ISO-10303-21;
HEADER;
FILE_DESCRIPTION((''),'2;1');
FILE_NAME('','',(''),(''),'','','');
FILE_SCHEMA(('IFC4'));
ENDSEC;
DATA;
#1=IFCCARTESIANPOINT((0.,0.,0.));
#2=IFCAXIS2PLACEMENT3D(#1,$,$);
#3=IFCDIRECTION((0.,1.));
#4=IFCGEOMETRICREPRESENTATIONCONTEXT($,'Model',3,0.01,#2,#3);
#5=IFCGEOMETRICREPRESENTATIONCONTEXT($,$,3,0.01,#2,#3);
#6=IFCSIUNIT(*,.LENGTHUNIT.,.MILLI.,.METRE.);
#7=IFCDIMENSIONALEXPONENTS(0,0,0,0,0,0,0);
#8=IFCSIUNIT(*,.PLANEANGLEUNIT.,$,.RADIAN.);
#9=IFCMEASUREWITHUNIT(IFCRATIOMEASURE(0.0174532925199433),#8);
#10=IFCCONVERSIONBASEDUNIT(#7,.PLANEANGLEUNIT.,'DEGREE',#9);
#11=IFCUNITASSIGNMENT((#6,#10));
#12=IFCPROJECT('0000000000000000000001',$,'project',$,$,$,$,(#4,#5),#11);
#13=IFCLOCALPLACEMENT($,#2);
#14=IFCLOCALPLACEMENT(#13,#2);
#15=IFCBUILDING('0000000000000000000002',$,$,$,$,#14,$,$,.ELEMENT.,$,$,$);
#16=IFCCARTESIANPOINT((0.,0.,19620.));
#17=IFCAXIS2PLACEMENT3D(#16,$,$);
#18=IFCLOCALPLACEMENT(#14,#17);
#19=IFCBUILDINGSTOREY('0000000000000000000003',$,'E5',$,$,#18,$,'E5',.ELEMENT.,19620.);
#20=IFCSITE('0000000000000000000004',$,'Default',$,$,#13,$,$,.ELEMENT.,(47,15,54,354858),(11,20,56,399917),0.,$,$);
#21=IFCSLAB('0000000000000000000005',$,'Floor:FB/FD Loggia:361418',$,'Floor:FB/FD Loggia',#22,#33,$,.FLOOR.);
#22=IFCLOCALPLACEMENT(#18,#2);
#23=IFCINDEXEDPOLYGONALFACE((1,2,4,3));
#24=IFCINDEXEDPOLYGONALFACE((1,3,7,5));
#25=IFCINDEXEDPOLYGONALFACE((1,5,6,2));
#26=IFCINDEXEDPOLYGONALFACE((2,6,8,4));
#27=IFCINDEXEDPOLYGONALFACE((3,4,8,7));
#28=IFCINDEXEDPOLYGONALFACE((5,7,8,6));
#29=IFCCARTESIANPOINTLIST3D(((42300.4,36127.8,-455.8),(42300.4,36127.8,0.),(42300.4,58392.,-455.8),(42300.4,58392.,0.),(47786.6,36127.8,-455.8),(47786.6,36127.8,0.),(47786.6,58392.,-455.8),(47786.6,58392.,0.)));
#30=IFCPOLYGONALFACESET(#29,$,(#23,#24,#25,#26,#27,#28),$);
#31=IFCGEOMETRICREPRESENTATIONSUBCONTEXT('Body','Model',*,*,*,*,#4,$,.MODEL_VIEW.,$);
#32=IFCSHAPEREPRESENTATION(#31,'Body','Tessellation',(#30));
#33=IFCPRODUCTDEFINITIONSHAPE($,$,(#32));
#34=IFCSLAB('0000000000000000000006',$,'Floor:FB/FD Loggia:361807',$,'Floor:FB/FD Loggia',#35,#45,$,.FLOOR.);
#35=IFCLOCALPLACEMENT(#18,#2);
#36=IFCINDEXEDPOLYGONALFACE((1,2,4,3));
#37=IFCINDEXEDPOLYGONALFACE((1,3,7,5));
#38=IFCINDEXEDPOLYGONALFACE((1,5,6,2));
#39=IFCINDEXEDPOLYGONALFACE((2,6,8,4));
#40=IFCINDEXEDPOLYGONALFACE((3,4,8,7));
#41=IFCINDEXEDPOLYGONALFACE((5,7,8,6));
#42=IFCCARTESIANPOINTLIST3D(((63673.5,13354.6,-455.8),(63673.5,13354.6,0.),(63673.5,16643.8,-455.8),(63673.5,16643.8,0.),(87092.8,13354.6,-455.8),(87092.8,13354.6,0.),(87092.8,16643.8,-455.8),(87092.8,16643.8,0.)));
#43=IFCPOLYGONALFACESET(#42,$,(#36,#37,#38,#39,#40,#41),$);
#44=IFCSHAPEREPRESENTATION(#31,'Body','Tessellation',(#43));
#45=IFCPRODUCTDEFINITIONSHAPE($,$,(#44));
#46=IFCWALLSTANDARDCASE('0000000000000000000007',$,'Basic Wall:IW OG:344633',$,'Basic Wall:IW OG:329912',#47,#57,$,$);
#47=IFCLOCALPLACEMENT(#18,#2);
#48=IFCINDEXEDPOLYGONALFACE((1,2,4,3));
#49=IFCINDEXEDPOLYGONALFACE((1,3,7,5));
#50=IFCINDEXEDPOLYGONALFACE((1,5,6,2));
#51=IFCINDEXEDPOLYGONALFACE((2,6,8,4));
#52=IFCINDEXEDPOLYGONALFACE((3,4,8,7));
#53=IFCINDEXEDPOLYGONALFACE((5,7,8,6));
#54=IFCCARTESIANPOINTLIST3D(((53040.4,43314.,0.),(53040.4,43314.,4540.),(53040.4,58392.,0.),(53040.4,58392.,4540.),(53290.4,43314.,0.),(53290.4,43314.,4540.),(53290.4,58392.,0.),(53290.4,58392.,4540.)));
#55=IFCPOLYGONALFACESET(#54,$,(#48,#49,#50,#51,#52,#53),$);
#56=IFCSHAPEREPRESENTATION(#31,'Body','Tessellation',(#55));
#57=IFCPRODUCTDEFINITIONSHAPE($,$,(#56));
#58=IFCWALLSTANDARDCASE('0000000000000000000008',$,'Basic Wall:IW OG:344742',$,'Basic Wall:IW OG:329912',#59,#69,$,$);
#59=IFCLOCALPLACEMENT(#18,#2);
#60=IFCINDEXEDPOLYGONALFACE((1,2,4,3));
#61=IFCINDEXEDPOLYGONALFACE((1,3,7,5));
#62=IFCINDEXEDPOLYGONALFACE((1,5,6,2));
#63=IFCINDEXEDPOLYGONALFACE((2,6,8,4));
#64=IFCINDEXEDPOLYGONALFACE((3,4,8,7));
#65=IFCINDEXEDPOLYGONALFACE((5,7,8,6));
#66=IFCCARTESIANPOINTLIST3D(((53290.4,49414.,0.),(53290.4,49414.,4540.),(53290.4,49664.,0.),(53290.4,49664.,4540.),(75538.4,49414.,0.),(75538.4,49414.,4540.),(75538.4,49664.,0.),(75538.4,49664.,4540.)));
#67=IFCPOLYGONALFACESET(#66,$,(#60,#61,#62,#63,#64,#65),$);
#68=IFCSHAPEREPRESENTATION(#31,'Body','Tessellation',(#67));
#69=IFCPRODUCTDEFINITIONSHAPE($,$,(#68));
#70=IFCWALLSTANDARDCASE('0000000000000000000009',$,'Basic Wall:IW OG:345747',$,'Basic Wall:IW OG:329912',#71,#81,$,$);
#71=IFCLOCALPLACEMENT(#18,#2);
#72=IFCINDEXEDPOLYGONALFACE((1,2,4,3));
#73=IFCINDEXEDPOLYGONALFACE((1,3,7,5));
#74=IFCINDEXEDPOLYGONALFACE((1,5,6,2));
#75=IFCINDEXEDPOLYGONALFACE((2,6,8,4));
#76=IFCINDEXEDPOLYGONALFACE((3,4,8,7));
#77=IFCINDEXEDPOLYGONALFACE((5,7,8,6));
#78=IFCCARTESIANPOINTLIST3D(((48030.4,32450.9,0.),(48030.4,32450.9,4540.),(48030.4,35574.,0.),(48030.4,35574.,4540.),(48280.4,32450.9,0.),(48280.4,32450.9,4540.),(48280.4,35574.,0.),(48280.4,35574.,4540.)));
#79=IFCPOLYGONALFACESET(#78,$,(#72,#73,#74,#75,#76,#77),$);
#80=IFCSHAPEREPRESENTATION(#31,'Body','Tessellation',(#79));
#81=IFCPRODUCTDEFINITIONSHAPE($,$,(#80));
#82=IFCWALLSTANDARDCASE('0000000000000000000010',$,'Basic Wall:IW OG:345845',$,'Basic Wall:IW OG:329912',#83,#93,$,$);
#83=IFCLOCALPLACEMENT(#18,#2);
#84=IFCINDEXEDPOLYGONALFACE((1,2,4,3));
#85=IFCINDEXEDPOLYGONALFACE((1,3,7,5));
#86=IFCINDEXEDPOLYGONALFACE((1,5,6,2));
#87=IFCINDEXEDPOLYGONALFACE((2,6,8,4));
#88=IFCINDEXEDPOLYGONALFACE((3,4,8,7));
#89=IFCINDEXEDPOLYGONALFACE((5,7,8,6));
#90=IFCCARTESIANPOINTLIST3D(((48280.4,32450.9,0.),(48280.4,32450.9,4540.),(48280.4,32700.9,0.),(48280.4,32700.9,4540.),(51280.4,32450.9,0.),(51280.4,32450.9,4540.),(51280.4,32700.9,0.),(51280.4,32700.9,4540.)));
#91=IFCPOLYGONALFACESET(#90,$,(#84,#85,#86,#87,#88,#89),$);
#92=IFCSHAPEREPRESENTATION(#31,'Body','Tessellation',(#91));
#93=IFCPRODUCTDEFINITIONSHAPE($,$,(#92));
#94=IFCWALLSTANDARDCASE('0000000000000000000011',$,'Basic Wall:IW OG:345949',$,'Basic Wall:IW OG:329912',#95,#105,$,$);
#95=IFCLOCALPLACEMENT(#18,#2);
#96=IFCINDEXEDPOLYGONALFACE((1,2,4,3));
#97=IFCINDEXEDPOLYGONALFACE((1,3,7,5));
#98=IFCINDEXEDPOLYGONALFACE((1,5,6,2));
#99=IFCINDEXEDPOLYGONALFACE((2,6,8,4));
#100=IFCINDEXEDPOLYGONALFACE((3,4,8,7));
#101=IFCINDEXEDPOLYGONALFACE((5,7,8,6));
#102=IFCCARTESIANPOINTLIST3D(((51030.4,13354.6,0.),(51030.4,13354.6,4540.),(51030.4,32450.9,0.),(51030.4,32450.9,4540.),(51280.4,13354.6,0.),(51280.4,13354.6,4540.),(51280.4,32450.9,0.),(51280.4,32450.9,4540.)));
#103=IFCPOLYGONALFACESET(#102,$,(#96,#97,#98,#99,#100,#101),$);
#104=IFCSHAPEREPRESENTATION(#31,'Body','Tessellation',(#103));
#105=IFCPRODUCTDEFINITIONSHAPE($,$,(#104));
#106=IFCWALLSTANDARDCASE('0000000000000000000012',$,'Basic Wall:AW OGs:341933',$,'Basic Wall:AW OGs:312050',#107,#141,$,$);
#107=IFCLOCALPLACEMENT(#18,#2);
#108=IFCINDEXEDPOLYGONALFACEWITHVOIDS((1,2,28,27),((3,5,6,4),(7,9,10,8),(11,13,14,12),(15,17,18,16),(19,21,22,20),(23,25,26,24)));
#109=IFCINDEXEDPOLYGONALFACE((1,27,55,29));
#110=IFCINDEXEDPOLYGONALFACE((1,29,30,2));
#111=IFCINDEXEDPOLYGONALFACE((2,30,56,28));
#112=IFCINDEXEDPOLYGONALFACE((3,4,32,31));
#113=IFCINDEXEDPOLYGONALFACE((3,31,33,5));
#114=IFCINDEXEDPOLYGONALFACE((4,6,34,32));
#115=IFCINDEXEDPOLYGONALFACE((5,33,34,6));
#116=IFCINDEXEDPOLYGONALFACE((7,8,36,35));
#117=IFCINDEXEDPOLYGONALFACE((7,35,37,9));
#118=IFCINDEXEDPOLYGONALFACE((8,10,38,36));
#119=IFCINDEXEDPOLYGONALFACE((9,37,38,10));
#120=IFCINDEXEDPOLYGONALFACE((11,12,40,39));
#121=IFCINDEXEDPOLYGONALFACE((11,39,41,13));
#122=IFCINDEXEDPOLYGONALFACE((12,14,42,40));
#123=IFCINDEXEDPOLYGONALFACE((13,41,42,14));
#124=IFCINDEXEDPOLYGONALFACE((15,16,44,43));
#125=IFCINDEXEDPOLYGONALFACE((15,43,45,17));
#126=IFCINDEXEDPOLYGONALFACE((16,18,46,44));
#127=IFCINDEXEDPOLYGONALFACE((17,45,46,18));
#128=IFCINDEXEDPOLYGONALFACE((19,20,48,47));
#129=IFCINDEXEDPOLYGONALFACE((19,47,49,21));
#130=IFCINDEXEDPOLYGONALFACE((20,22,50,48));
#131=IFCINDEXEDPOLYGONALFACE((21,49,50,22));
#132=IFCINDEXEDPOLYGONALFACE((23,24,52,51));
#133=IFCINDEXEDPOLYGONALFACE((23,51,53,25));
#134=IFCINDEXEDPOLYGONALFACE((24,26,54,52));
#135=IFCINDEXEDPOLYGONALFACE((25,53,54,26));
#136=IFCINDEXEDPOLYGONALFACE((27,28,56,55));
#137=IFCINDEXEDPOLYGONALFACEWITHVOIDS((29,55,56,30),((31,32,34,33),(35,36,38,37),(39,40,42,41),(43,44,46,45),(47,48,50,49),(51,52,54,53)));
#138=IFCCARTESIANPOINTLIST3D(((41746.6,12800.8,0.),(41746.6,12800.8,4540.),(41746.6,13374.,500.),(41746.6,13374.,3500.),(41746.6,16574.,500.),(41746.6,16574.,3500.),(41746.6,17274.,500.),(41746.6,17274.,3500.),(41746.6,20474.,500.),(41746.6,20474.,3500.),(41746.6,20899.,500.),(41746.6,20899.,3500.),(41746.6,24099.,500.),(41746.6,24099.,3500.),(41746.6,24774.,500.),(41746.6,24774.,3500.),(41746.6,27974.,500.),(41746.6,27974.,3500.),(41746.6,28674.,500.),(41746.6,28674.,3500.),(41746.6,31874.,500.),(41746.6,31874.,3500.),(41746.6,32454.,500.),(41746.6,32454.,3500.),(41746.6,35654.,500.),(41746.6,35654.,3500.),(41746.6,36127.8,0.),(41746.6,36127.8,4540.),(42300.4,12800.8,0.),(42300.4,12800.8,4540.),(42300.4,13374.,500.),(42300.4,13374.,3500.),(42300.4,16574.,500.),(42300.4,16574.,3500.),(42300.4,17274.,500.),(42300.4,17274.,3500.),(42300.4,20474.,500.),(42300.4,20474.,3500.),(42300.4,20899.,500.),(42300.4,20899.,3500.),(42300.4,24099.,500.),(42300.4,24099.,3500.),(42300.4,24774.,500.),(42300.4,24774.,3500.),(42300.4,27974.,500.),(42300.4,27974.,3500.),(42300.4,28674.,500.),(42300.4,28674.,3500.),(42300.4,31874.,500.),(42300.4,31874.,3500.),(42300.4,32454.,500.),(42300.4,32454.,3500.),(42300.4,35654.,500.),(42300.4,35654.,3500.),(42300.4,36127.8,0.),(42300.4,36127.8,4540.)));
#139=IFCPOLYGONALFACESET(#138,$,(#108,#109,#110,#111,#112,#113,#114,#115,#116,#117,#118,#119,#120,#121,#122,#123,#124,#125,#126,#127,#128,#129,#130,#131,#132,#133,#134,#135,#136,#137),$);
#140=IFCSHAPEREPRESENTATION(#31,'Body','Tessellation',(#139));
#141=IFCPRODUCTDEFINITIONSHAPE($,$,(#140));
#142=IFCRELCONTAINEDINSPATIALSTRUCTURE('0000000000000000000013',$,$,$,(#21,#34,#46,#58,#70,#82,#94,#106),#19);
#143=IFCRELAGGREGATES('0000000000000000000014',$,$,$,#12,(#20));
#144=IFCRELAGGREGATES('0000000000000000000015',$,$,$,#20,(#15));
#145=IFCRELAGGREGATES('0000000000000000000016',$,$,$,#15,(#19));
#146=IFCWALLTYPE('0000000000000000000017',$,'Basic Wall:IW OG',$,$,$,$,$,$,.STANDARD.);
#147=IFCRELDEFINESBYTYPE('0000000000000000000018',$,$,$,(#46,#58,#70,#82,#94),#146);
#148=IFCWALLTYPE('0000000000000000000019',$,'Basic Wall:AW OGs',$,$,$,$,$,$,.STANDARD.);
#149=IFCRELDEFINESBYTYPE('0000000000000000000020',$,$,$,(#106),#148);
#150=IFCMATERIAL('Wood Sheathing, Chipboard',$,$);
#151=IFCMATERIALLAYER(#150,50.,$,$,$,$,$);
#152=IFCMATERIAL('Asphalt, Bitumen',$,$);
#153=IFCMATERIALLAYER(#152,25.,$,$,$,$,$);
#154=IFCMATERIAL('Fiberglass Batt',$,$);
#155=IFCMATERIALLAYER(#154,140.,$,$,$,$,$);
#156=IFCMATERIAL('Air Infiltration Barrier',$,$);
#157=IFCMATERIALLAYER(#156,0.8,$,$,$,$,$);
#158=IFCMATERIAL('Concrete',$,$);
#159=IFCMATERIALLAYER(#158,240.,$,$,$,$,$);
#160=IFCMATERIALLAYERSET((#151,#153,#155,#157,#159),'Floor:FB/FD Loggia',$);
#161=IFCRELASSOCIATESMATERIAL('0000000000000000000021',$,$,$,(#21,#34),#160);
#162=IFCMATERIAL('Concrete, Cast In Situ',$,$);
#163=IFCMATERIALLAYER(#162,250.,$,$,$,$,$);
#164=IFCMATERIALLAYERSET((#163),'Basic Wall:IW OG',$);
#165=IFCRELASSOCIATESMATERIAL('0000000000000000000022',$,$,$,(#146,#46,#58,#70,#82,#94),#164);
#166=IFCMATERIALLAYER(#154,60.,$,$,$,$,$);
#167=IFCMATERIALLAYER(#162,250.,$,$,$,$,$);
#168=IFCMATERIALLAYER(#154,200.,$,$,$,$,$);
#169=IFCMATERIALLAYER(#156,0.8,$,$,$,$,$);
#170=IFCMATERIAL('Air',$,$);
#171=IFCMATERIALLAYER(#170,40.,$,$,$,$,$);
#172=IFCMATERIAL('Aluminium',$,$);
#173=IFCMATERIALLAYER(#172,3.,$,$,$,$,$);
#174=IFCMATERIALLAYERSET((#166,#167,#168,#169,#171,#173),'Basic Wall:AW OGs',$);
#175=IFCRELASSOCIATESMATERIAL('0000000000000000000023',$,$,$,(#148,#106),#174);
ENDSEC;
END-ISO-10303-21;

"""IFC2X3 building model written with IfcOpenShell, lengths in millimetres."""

from ifc_helpers import new_model, entity, si_unit, converted_unit, direction, frame, frame_2d, origin, place, context, subcontext, project, spatial, rectangle, extrude, material, layer, layer_set, layer_usage, type_object, element, save


model = new_model("IFC2X3")

# Units and contexts
model_context = context("Model", 3, precision=0.01, world=origin(), true_north=direction((0.0, 1.0)))
context_of_model = context(None, 3, precision=0.01, world=origin(), true_north=direction((0.0, 1.0)))
body_context = subcontext(model_context, "Body", "Model", "MODEL_VIEW")
ifc_project = project(units=[si_unit("LENGTHUNIT", "METRE", prefix="MILLI"), converted_unit("PLANEANGLEUNIT", "DEGREE", entity("IfcRatioMeasure", 0.0174532925199433), si_unit("PLANEANGLEUNIT", "RADIAN"), dimensions=[0, 0, 0, 0, 0, 0, 0])], contexts=[model_context, context_of_model])

# Site, building, storey
site_placement = place(None, origin())
site = spatial("IfcSite", under=ifc_project, at=site_placement, Name="Default", CompositionType="ELEMENT", RefLatitude=(47, 15, 54, 354858), RefLongitude=(11, 20, 56, 399917), RefElevation=0.0)
building_placement = place(site_placement, origin())
building = spatial("IfcBuilding", under=site, at=building_placement, CompositionType="ELEMENT")
storey_placement = place(building_placement, frame((0.0, 0.0, 19620.0)))
storey = spatial("IfcBuildingStorey", under=building, at=storey_placement, Name="E5", LongName="E5", CompositionType="ELEMENT", Elevation=19620.0)

# Shared definitions
ifc_material_1 = material(Name="Air Infiltration Barrier")
ifc_material_2 = material(Name="Fiberglass Batt")
ifc_material_3 = material(Name="Concrete")

# Slabs
ifc_material_4 = material(Name="Wood Sheathing, Chipboard")
ifc_layer_1 = layer(ifc_material_4, 50.0)
ifc_material_5 = material(Name="Asphalt, Bitumen")
ifc_layer_2 = layer(ifc_material_5, 25.0)
ifc_layer_3 = layer(ifc_material_2, 140.0)
ifc_layer_4 = layer(ifc_material_1, 0.8)
ifc_layer_5 = layer(ifc_material_3, 240.0)
ifc_layer_set_1 = layer_set([ifc_layer_1, ifc_layer_2, ifc_layer_3, ifc_layer_4, ifc_layer_5], Name="Floor:FB/FD Loggia")
ifc_layer_usage_1 = layer_usage(ifc_layer_set_1, "AXIS3", "POSITIVE", 0.0)
slab_1_placement = place(storey_placement, origin())
element("IfcSlab", 1, at=slab_1_placement, inside=storey, material=ifc_layer_usage_1, Name="Floor:FB/FD Loggia:361418", ObjectType="Floor:FB/FD Loggia", PredefinedType="FLOOR", context=body_context, shape_type="SweptSolid", body=[
    extrude(rectangle(XDim=22264.3, YDim=5486.2, at=frame_2d((0.0, 0.0), x_axis=(1.0, 0.0))), frame((45043.5, 47259.9, 0.0), z_axis=(0.0, 0.0, -1.0), x_axis=(0.0, 1.0, 0.0)), (0.0, 0.0, 1.0), 455.8),
])
ifc_layer_usage_2 = layer_usage(ifc_layer_set_1, "AXIS3", "POSITIVE", 0.0)
slab_2_placement = place(storey_placement, origin())
element("IfcSlab", 2, at=slab_2_placement, inside=storey, material=ifc_layer_usage_2, Name="Floor:FB/FD Loggia:361807", ObjectType="Floor:FB/FD Loggia", PredefinedType="FLOOR", context=body_context, shape_type="SweptSolid", body=[
    extrude(rectangle(XDim=3289.2, YDim=23419.3, at=frame_2d((0.0, 0.0), x_axis=(1.0, 0.0))), frame((75383.1, 14999.2, 0.0), z_axis=(0.0, 0.0, -1.0), x_axis=(0.0, 1.0, 0.0)), (0.0, 0.0, 1.0), 455.8),
])

# Walls
ifc_material_6 = material(Name="Concrete, Cast In Situ")
ifc_layer_6 = layer(ifc_material_6, 250.0)
ifc_layer_set_2 = layer_set([ifc_layer_6], Name="Basic Wall:IW OG")
ifc_layer_usage_3 = layer_usage(ifc_layer_set_2, "AXIS2", "NEGATIVE", 125.0)
wall_type_1 = type_object("IfcWallType", Name="Basic Wall:IW OG", PredefinedType="STANDARD", material=ifc_layer_set_2)
wall_1_placement = place(storey_placement, frame((53165.4, 58392.0, 0.0), z_axis=(0.0, 0.0, 1.0), x_axis=(0.0, -1.0, 0.0)))
element("IfcWallStandardCase", 3, at=wall_1_placement, inside=storey, type_object=wall_type_1, material=ifc_layer_usage_3, Name="Basic Wall:IW OG:344633", ObjectType="Basic Wall:IW OG:329912", context=body_context, shape_type="SweptSolid", body=[
    extrude(rectangle(XDim=15078.0, YDim=250.0, at=frame_2d((7539.0, 0.0), x_axis=(-1.0, 0.0))), origin(), (0.0, 0.0, 1.0), 4540.0),
])
ifc_layer_usage_4 = layer_usage(ifc_layer_set_2, "AXIS2", "NEGATIVE", 125.0)
wall_2_placement = place(storey_placement, frame((53290.4, 49539.0, 0.0)))
element("IfcWallStandardCase", 4, at=wall_2_placement, inside=storey, type_object=wall_type_1, material=ifc_layer_usage_4, Name="Basic Wall:IW OG:344742", ObjectType="Basic Wall:IW OG:329912", context=body_context, shape_type="SweptSolid", body=[
    extrude(rectangle(XDim=22248.1, YDim=250.0, at=frame_2d((11124.0, 0.0), x_axis=(-1.0, 0.0))), origin(), (0.0, 0.0, 1.0), 4540.0),
])
ifc_layer_usage_5 = layer_usage(ifc_layer_set_2, "AXIS2", "NEGATIVE", 125.0)
wall_3_placement = place(storey_placement, frame((48155.4, 35574.0, 0.0), z_axis=(0.0, 0.0, 1.0), x_axis=(0.0, -1.0, 0.0)))
element("IfcWallStandardCase", 5, at=wall_3_placement, inside=storey, type_object=wall_type_1, material=ifc_layer_usage_5, Name="Basic Wall:IW OG:345747", ObjectType="Basic Wall:IW OG:329912", context=body_context, shape_type="SweptSolid", body=[
    extrude(rectangle(XDim=3123.1, YDim=250.0, at=frame_2d((1561.5, 0.0), x_axis=(-1.0, 0.0))), origin(), (0.0, 0.0, 1.0), 4540.0),
])
ifc_layer_usage_6 = layer_usage(ifc_layer_set_2, "AXIS2", "NEGATIVE", 125.0)
wall_4_placement = place(storey_placement, frame((48280.4, 32575.9, 0.0)))
element("IfcWallStandardCase", 6, at=wall_4_placement, inside=storey, type_object=wall_type_1, material=ifc_layer_usage_6, Name="Basic Wall:IW OG:345845", ObjectType="Basic Wall:IW OG:329912", context=body_context, shape_type="SweptSolid", body=[
    extrude(rectangle(XDim=3000.0, YDim=250.0, at=frame_2d((1500.0, 0.0), x_axis=(-1.0, 0.0))), origin(), (0.0, 0.0, 1.0), 4540.0),
])
ifc_layer_usage_7 = layer_usage(ifc_layer_set_2, "AXIS2", "NEGATIVE", 125.0)
wall_5_placement = place(storey_placement, frame((51155.4, 32450.9, 0.0), z_axis=(0.0, 0.0, 1.0), x_axis=(0.0, -1.0, 0.0)))
element("IfcWallStandardCase", 7, at=wall_5_placement, inside=storey, type_object=wall_type_1, material=ifc_layer_usage_7, Name="Basic Wall:IW OG:345949", ObjectType="Basic Wall:IW OG:329912", context=body_context, shape_type="SweptSolid", body=[
    extrude(rectangle(XDim=19096.2, YDim=250.0, at=frame_2d((9548.1, 0.0), x_axis=(-1.0, 0.0))), origin(), (0.0, 0.0, 1.0), 4540.0),
])

# Wall, openings
ifc_layer_7 = layer(ifc_material_2, 60.0)
ifc_layer_8 = layer(ifc_material_6, 250.0)
ifc_layer_9 = layer(ifc_material_2, 200.0)
ifc_layer_10 = layer(ifc_material_1, 0.8)
ifc_material_7 = material(Name="Air")
ifc_layer_11 = layer(ifc_material_7, 40.0)
ifc_material_8 = material(Name="Aluminium")
ifc_layer_12 = layer(ifc_material_8, 3.0)
ifc_layer_set_3 = layer_set([ifc_layer_7, ifc_layer_8, ifc_layer_9, ifc_layer_10, ifc_layer_11, ifc_layer_12], Name="Basic Wall:AW OGs")
ifc_layer_usage_8 = layer_usage(ifc_layer_set_3, "AXIS2", "NEGATIVE", 276.9)
wall_type_2 = type_object("IfcWallType", Name="Basic Wall:AW OGs", PredefinedType="STANDARD", material=ifc_layer_set_3)
wall_6_placement = place(storey_placement, frame((42023.5, 36127.8, 0.0), z_axis=(0.0, 0.0, 1.0), x_axis=(0.0, -1.0, 0.0)))
wall_6 = element("IfcWallStandardCase", 8, at=wall_6_placement, inside=storey, type_object=wall_type_2, material=ifc_layer_usage_8, Name="Basic Wall:AW OGs:341933", ObjectType="Basic Wall:AW OGs:312050", context=body_context, shape_type="SweptSolid", body=[
    extrude(rectangle(XDim=23326.9, YDim=553.8, at=frame_2d((11663.5, 0.0), x_axis=(-1.0, 0.0))), origin(), (0.0, 0.0, 1.0), 4540.0),
])
opening_1_placement = place(wall_6_placement, origin())
element("IfcOpeningElement", 9, at=opening_1_placement, cuts=wall_6, ObjectType="Opening", context=body_context, shape_type="SweptSolid", body=[
    extrude(rectangle(XDim=3000.0, YDim=553.8, at=frame_2d((0.0, 0.0), x_axis=(0.0, 1.0))), frame((23050.0, 276.9, 2000.0), z_axis=(0.0, 1.0, 0.0), x_axis=(-1.0, 0.0, 0.0)), (0.0, 0.0, 1.0), 8500.0),
])
opening_2_placement = place(wall_6_placement, frame((3673.8, 276.9, 500.0)))
element("IfcOpeningElement", 10, at=opening_2_placement, cuts=wall_6, ObjectType="Opening", context=body_context, shape_type="SweptSolid", body=[
    extrude(rectangle(XDim=3000.0, YDim=3200.0, at=frame_2d((1500.0, 1600.0), x_axis=(-1.0, 0.0))), frame((0.0, 0.0, 0.0), z_axis=(0.0, -1.0, 0.0), x_axis=(0.0, 0.0, 1.0)), (0.0, 0.0, 1.0), 553.8),
])
opening_3_placement = place(wall_6_placement, frame((7453.8, 276.9, 500.0)))
element("IfcOpeningElement", 11, at=opening_3_placement, cuts=wall_6, ObjectType="Opening", context=body_context, shape_type="SweptSolid", body=[
    extrude(rectangle(XDim=3000.0, YDim=3200.0, at=frame_2d((1500.0, 1600.0), x_axis=(-1.0, 0.0))), frame((0.0, 0.0, 0.0), z_axis=(0.0, -1.0, 0.0), x_axis=(0.0, 0.0, 1.0)), (0.0, 0.0, 1.0), 553.8),
])
opening_4_placement = place(wall_6_placement, frame((11353.8, 276.9, 500.0)))
element("IfcOpeningElement", 12, at=opening_4_placement, cuts=wall_6, ObjectType="Opening", context=body_context, shape_type="SweptSolid", body=[
    extrude(rectangle(XDim=3000.0, YDim=3200.0, at=frame_2d((1500.0, 1600.0), x_axis=(-1.0, 0.0))), frame((0.0, 0.0, 0.0), z_axis=(0.0, -1.0, 0.0), x_axis=(0.0, 0.0, 1.0)), (0.0, 0.0, 1.0), 553.8),
])
opening_5_placement = place(wall_6_placement, frame((15228.8, 276.9, 500.0)))
element("IfcOpeningElement", 13, at=opening_5_placement, cuts=wall_6, ObjectType="Opening", context=body_context, shape_type="SweptSolid", body=[
    extrude(rectangle(XDim=3000.0, YDim=3200.0, at=frame_2d((1500.0, 1600.0), x_axis=(-1.0, 0.0))), frame((0.0, 0.0, 0.0), z_axis=(0.0, -1.0, 0.0), x_axis=(0.0, 0.0, 1.0)), (0.0, 0.0, 1.0), 553.8),
])
opening_6_placement = place(wall_6_placement, frame((18853.8, 276.9, 500.0)))
element("IfcOpeningElement", 14, at=opening_6_placement, cuts=wall_6, ObjectType="Opening", context=body_context, shape_type="SweptSolid", body=[
    extrude(rectangle(XDim=3000.0, YDim=3200.0, at=frame_2d((1500.0, 1600.0), x_axis=(-1.0, 0.0))), frame((0.0, 0.0, 0.0), z_axis=(0.0, -1.0, 0.0), x_axis=(0.0, 0.0, 1.0)), (0.0, 0.0, 1.0), 553.8),
])
opening_7_placement = place(wall_6_placement, frame((22753.8, 276.9, 500.0)))
element("IfcOpeningElement", 15, at=opening_7_placement, cuts=wall_6, ObjectType="Opening", context=body_context, shape_type="SweptSolid", body=[
    extrude(rectangle(XDim=3000.0, YDim=3200.0, at=frame_2d((1500.0, 1600.0), x_axis=(-1.0, 0.0))), frame((0.0, 0.0, 0.0), z_axis=(0.0, -1.0, 0.0), x_axis=(0.0, 0.0, 1.0)), (0.0, 0.0, 1.0), 553.8),
])

save(model, "model.ifc")
